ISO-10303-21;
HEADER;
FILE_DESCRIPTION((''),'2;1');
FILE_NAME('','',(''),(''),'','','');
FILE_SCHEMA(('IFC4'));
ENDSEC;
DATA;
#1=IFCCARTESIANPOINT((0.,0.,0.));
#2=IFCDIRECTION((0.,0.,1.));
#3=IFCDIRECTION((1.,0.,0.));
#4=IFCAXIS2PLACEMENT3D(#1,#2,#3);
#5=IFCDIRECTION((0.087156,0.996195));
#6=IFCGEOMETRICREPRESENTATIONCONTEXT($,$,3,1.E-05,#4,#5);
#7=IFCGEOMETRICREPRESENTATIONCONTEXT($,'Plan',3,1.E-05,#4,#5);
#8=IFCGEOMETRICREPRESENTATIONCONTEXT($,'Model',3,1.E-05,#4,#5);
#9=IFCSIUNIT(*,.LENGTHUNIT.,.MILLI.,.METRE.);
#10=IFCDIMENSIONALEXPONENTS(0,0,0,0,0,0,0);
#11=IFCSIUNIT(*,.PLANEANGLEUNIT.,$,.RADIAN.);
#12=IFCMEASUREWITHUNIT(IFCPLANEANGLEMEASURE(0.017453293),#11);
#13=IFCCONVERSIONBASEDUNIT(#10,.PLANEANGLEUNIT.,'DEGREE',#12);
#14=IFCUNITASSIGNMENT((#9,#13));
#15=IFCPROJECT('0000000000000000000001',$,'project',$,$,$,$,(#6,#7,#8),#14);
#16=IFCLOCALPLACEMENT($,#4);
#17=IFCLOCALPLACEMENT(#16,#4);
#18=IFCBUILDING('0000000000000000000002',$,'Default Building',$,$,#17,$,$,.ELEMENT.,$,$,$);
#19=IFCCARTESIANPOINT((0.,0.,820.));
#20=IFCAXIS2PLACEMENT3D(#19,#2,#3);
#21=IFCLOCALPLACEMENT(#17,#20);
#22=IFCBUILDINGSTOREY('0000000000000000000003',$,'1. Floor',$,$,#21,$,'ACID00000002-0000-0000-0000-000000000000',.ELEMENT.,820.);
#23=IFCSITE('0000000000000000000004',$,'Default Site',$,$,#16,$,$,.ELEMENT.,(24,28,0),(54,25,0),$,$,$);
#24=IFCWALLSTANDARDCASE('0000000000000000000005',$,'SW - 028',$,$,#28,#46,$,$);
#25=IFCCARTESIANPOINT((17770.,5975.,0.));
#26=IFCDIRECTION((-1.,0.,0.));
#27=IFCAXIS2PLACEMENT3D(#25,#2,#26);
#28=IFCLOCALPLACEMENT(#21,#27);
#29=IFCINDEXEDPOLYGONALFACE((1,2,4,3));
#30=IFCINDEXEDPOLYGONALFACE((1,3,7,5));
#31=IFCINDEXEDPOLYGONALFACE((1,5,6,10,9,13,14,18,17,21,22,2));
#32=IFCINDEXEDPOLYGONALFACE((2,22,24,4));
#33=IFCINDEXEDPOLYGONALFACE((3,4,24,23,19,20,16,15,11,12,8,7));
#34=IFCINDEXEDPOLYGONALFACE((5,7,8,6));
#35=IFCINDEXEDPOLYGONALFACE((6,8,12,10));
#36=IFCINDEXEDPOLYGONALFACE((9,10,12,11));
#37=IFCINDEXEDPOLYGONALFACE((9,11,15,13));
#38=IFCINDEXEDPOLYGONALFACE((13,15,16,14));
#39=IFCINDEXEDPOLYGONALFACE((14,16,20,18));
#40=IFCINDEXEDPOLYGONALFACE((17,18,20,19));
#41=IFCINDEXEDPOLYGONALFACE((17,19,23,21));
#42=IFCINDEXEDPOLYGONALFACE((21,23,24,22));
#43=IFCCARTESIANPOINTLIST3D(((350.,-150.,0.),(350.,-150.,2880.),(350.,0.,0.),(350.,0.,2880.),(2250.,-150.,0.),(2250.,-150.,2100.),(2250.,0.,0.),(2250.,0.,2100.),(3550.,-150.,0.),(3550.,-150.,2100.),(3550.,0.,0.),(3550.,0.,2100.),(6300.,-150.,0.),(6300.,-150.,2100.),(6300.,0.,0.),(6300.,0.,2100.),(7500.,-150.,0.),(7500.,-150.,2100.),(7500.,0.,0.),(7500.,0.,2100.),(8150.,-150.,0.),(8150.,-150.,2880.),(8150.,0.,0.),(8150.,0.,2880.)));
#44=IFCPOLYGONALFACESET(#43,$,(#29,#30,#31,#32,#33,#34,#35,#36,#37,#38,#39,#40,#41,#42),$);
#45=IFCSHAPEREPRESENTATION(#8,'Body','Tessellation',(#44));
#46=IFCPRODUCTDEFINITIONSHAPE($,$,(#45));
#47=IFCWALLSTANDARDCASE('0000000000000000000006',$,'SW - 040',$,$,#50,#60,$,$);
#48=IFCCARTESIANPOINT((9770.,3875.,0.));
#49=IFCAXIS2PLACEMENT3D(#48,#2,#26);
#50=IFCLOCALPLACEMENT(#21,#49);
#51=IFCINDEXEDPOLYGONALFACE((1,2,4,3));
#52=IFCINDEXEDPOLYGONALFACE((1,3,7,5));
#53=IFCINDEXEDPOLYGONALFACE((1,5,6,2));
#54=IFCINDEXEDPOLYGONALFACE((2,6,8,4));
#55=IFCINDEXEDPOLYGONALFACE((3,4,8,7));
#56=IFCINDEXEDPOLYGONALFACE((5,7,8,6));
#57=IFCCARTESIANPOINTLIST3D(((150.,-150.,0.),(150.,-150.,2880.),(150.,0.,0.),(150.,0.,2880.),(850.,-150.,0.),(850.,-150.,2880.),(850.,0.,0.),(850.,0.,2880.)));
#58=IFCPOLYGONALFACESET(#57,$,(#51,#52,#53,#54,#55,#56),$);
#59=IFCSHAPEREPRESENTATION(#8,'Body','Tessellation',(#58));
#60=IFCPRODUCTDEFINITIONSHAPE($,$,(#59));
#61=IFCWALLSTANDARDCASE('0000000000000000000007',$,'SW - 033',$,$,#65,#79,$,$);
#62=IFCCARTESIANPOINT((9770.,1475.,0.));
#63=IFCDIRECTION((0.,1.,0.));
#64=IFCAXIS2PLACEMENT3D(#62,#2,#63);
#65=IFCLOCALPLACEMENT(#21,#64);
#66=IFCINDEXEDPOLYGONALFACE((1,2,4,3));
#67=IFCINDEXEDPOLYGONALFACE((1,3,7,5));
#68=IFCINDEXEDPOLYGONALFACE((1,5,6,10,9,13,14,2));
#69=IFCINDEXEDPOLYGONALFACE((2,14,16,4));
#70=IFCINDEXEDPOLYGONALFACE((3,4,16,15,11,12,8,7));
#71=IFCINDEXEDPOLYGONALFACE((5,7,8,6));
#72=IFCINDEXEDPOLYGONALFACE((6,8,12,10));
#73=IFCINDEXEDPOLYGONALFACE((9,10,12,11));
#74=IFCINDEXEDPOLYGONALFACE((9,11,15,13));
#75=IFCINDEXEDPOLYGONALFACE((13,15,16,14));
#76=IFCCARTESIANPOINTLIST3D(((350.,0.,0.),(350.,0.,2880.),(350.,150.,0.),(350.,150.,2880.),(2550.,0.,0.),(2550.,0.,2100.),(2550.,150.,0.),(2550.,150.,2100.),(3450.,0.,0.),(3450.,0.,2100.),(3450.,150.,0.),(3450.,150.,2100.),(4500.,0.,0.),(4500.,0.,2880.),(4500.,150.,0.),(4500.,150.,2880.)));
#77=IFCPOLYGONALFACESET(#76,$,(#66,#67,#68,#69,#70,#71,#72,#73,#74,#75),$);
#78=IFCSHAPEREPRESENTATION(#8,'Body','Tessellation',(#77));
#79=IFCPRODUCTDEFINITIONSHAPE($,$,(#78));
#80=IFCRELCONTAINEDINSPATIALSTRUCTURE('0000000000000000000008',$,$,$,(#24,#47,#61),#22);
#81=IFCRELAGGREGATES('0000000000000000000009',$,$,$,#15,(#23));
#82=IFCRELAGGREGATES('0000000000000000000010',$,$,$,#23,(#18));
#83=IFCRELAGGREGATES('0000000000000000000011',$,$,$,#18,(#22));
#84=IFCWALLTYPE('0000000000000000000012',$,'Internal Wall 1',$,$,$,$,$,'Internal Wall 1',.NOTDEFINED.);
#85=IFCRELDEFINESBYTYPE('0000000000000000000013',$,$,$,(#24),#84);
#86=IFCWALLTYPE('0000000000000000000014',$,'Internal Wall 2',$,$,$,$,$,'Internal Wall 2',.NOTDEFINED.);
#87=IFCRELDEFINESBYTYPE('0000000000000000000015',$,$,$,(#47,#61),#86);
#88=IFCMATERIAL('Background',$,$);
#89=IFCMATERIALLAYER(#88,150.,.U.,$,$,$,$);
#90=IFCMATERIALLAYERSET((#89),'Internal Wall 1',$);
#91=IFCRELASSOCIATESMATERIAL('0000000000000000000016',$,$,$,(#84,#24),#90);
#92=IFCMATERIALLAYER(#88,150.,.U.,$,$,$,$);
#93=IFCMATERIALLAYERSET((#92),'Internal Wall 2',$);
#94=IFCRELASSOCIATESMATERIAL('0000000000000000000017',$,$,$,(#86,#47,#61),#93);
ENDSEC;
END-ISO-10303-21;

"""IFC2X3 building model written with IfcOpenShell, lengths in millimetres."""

from ifc_helpers import new_model, entity, si_unit, converted_unit, direction, frame, frame_2d, origin_with_axes, place, context, project, spatial, polyline, rectangle, outline, extrude, material, layer, layer_set, layer_usage, type_object, element, save


model = new_model("IFC2X3")

# Units and contexts
context_of_model = context(None, 3, precision=1e-05, world=origin_with_axes(), true_north=direction((0.087156, 0.996195)))
plan_context = context("Plan", 3, precision=1e-05, world=origin_with_axes(), true_north=direction((0.087156, 0.996195)))
model_context = context("Model", 3, precision=1e-05, world=origin_with_axes(), true_north=direction((0.087156, 0.996195)))
ifc_project = project(units=[si_unit("LENGTHUNIT", "METRE", prefix="MILLI"), converted_unit("PLANEANGLEUNIT", "DEGREE", entity("IfcPlaneAngleMeasure", 0.017453293), si_unit("PLANEANGLEUNIT", "RADIAN"), dimensions=[0, 0, 0, 0, 0, 0, 0])], contexts=[context_of_model, plan_context, model_context])

# Site, building, storey
site_placement = place(None, origin_with_axes())
site = spatial("IfcSite", under=ifc_project, at=site_placement, Name="Default Site", CompositionType="ELEMENT", RefLatitude=(24, 28, 0), RefLongitude=(54, 25, 0))
building_placement = place(site_placement, origin_with_axes())
building = spatial("IfcBuilding", under=site, at=building_placement, Name="Default Building", CompositionType="ELEMENT")
storey_placement = place(building_placement, frame((0.0, 0.0, 820.0), z_axis=(0.0, 0.0, 1.0), x_axis=(1.0, 0.0, 0.0)))
storey = spatial("IfcBuildingStorey", under=building, at=storey_placement, Name="1. Floor", LongName="ACID00000002-0000-0000-0000-000000000000", CompositionType="ELEMENT", Elevation=820.0)

# Shared definitions
ifc_material_1 = material(Name="Background")

# Wall, openings
ifc_layer_1 = layer(ifc_material_1, 150.0, ventilated="UNKNOWN")
ifc_layer_set_1 = layer_set([ifc_layer_1], Name="Internal Wall 1")
ifc_layer_usage_1 = layer_usage(ifc_layer_set_1, "AXIS2", "NEGATIVE", 0.0)
wall_type_1 = type_object("IfcWallType", Name="Internal Wall 1", ElementType="Internal Wall 1", PredefinedType="NOTDEFINED", material=ifc_layer_set_1)
wall_1_placement = place(storey_placement, frame((17770.0, 5975.0, 0.0), z_axis=(0.0, 0.0, 1.0), x_axis=(-1.0, 0.0, 0.0)))
wall_1 = element("IfcWallStandardCase", 1, at=wall_1_placement, inside=storey, type_object=wall_type_1, material=ifc_layer_usage_1, Name="SW - 028", context=model_context, shape_type="SweptSolid", body=[
    extrude(outline(polyline([(350.0, -150.0), (8150.0, -150.0), (8150.0, 0.0), (350.0, 0.0), (350.0, -150.0)])), origin_with_axes(), (0.0, 0.0, 1.0), 2880.0),
])
opening_1_placement = place(wall_1_placement, frame((6900.0, -150.0, 0.0), z_axis=(0.0, 0.0, 1.0), x_axis=(1.0, 0.0, 0.0)))
element("IfcOpeningElement", 2, at=opening_1_placement, cuts=wall_1, ObjectType="Opening", context=model_context, shape_type="SweptSolid", body=[
    extrude(rectangle(XDim=1200.0, YDim=2100.0, at=frame_2d((0.0, 1050.0), x_axis=(-1.0, 0.0))), frame((0.0, 0.0, 0.0), z_axis=(0.0, 1.0, 0.0), x_axis=(-1.0, 0.0, 0.0)), (0.0, 0.0, 1.0), 150.0),
])
opening_2_placement = place(wall_1_placement, frame((2900.0, -150.0, 0.0), z_axis=(0.0, 0.0, 1.0), x_axis=(1.0, 0.0, 0.0)))
element("IfcOpeningElement", 3, at=opening_2_placement, inside=storey, cuts=wall_1, ObjectType="Opening", context=model_context, shape_type="SweptSolid", body=[
    extrude(rectangle(XDim=1300.0, YDim=2100.0, at=frame_2d((0.0, 1050.0), x_axis=(-1.0, 0.0))), frame((0.0, 0.0, 0.0), z_axis=(0.0, 1.0, 0.0), x_axis=(-1.0, 0.0, 0.0)), (0.0, 0.0, 1.0), 150.0),
])

# Wall
ifc_layer_2 = layer(ifc_material_1, 150.0, ventilated="UNKNOWN")
ifc_layer_set_2 = layer_set([ifc_layer_2], Name="Internal Wall 2")
ifc_layer_usage_2 = layer_usage(ifc_layer_set_2, "AXIS2", "NEGATIVE", 0.0)
wall_type_2 = type_object("IfcWallType", Name="Internal Wall 2", ElementType="Internal Wall 2", PredefinedType="NOTDEFINED", material=ifc_layer_set_2)
wall_2_placement = place(storey_placement, frame((9770.0, 3875.0, 0.0), z_axis=(0.0, 0.0, 1.0), x_axis=(-1.0, 0.0, 0.0)))
element("IfcWallStandardCase", 4, at=wall_2_placement, inside=storey, type_object=wall_type_2, material=ifc_layer_usage_2, Name="SW - 040", context=model_context, shape_type="SweptSolid", body=[
    extrude(outline(polyline([(150.0, -150.0), (850.0, -150.0), (850.0, 0.0), (150.0, 0.0), (150.0, -150.0)])), origin_with_axes(), (0.0, 0.0, 1.0), 2880.0),
])

# Wall, opening
ifc_layer_usage_3 = layer_usage(ifc_layer_set_2, "AXIS2", "POSITIVE", 0.0)
wall_3_placement = place(storey_placement, frame((9770.0, 1475.0, 0.0), z_axis=(0.0, 0.0, 1.0), x_axis=(0.0, 1.0, 0.0)))
wall_3 = element("IfcWallStandardCase", 5, at=wall_3_placement, inside=storey, type_object=wall_type_2, material=ifc_layer_usage_3, Name="SW - 033", context=model_context, shape_type="SweptSolid", body=[
    extrude(outline(polyline([(350.0, 0.0), (4500.0, 0.0), (4500.0, 150.0), (350.0, 150.0), (350.0, 0.0)])), origin_with_axes(), (0.0, 0.0, 1.0), 2880.0),
])
opening_3_placement = place(wall_3_placement, frame((3000.0, 0.0, 0.0), z_axis=(0.0, 0.0, 1.0), x_axis=(1.0, 0.0, 0.0)))
element("IfcOpeningElement", 6, at=opening_3_placement, cuts=wall_3, ObjectType="Opening", context=model_context, shape_type="SweptSolid", body=[
    extrude(rectangle(XDim=900.0, YDim=2100.0, at=frame_2d((0.0, 1050.0), x_axis=(-1.0, 0.0))), frame((0.0, 0.0, 0.0), z_axis=(0.0, 1.0, 0.0), x_axis=(-1.0, 0.0, 0.0)), (0.0, 0.0, 1.0), 150.0),
])

save(model, "model.ifc")
